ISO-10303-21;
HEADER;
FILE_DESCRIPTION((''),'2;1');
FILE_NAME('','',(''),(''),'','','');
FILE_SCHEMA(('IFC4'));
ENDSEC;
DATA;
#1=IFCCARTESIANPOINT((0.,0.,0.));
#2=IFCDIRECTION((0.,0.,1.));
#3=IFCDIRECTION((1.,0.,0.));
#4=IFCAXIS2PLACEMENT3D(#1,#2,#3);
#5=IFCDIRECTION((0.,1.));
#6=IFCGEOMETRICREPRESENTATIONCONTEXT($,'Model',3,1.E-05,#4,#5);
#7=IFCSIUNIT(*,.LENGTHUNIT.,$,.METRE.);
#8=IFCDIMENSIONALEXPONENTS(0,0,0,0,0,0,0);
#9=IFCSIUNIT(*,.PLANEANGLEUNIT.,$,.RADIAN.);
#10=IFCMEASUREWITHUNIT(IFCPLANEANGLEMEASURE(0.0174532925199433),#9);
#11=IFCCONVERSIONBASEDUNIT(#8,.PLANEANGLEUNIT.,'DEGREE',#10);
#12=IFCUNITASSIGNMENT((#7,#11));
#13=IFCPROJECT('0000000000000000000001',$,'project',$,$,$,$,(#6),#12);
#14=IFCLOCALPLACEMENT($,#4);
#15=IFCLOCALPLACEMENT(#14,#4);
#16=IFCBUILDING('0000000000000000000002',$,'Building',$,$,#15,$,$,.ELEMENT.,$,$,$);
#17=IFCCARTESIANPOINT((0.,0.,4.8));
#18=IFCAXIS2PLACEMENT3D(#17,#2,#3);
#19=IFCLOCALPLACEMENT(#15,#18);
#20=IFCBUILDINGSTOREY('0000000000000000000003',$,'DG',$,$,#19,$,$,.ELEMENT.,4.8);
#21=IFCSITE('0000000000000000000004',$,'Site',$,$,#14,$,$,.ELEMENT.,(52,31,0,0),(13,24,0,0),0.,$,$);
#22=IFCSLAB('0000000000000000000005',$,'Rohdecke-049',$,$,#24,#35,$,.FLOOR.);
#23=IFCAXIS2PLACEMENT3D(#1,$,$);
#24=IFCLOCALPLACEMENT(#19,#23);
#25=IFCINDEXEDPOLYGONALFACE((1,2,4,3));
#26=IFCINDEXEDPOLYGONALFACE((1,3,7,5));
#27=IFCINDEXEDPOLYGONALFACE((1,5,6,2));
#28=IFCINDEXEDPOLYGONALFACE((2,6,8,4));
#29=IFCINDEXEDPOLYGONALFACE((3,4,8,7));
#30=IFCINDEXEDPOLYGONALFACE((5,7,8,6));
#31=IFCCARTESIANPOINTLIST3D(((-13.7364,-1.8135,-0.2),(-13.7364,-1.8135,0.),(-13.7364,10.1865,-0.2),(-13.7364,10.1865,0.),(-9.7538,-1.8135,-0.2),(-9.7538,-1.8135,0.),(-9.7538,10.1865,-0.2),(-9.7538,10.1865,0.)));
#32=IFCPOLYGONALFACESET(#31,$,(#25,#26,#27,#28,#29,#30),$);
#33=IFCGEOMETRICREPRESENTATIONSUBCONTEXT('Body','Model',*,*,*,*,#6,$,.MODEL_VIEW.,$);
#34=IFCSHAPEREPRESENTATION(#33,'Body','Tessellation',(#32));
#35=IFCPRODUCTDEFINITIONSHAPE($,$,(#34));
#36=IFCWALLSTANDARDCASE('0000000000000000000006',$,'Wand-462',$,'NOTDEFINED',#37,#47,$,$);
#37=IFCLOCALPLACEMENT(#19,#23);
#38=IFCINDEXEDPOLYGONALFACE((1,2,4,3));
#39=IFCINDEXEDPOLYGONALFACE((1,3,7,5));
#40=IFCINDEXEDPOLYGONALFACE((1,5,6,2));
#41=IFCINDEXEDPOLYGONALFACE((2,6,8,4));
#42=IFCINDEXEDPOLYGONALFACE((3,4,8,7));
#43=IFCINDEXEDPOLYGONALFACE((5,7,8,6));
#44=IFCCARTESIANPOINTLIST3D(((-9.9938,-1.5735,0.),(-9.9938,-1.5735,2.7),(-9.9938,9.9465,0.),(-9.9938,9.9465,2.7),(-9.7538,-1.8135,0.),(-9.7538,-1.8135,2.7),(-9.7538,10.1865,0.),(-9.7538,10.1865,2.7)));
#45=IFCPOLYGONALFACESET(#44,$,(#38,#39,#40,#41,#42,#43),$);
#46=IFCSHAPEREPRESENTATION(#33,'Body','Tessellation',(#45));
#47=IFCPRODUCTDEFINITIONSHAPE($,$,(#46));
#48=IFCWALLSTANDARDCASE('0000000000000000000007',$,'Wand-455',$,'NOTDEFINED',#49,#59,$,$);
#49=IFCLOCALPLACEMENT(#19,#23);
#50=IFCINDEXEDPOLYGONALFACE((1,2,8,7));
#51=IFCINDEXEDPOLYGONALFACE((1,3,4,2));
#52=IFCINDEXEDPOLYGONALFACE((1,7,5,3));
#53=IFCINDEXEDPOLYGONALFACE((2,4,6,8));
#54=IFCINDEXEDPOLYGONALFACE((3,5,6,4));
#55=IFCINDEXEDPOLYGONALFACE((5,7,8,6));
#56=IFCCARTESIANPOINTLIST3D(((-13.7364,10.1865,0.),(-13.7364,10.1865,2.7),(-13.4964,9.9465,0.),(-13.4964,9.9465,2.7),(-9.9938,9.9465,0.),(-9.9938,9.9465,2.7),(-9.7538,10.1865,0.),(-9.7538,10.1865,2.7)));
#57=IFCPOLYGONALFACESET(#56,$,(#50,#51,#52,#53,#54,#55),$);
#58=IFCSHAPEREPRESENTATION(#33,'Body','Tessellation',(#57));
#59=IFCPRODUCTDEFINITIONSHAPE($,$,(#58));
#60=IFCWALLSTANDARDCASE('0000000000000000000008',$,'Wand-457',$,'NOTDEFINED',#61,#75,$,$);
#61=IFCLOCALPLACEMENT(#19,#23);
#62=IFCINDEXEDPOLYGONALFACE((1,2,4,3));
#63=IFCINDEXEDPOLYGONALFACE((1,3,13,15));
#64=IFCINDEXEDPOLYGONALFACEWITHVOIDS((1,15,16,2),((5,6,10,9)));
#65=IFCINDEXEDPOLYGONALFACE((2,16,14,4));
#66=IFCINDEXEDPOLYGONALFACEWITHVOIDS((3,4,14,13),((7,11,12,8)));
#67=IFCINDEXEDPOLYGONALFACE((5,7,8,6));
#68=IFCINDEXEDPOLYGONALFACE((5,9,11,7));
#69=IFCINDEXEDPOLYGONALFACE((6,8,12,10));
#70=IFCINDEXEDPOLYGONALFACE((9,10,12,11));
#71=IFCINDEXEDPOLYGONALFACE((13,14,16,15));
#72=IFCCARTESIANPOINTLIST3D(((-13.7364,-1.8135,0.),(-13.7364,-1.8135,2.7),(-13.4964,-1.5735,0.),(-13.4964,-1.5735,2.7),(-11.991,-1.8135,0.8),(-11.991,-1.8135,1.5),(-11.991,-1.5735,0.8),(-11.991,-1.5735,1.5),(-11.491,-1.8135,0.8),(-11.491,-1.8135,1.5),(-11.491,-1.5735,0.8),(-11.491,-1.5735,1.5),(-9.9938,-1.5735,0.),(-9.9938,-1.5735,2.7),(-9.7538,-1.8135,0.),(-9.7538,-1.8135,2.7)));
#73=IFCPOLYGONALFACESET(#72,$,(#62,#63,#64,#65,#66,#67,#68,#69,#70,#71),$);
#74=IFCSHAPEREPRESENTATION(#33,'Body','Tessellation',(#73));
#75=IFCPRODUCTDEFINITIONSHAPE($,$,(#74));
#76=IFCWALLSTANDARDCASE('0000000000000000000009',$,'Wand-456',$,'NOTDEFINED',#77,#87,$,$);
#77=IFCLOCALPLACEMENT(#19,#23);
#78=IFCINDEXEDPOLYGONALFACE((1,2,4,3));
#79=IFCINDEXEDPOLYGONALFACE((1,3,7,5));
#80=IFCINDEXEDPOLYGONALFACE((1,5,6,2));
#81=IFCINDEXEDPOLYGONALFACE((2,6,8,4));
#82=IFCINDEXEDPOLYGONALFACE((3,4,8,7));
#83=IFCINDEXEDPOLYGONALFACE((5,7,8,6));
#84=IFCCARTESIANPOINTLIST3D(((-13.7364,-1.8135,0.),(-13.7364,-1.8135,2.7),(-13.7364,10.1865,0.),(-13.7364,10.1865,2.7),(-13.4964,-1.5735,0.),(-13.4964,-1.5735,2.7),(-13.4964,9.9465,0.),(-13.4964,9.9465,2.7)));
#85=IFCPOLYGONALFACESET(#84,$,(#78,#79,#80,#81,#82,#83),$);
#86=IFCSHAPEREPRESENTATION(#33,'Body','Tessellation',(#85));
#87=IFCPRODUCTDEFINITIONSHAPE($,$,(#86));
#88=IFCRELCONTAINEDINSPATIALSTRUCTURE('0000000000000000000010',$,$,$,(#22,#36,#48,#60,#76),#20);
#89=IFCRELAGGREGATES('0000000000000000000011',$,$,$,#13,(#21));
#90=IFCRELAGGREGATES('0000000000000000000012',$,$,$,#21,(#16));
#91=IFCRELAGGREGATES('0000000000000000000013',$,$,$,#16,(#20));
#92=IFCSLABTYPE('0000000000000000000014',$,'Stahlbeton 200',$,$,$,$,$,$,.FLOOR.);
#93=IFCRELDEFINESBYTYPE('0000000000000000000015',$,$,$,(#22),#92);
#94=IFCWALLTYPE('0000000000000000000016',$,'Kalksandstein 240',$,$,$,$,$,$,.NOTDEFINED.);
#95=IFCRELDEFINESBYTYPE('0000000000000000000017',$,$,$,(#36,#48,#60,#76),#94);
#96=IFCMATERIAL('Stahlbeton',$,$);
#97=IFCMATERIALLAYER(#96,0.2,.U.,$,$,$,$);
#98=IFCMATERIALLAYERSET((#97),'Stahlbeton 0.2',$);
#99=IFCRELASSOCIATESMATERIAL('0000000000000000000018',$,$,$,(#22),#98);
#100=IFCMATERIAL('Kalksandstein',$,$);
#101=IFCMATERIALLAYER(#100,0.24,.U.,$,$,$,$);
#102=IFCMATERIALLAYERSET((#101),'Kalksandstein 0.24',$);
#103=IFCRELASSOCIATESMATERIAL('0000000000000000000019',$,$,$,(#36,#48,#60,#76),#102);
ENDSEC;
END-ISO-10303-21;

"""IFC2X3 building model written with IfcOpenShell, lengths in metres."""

from ifc_helpers import new_model, entity, si_unit, converted_unit, direction, frame, origin_with_axes, origin_2d_with_axis, place, context, subcontext, project, spatial, polyline, rectangle, outline, extrude, material, layer, layer_set, layer_usage, type_object, element, save


model = new_model("IFC2X3")

# Units and contexts
model_context = context("Model", 3, precision=1e-05, world=origin_with_axes(), true_north=direction((0.0, 1.0)))
body_context = subcontext(model_context, "Body", "Model", "MODEL_VIEW")
ifc_project = project(units=[si_unit("LENGTHUNIT", "METRE"), converted_unit("PLANEANGLEUNIT", "DEGREE", entity("IfcPlaneAngleMeasure", 0.0174532925199433), si_unit("PLANEANGLEUNIT", "RADIAN"), dimensions=[0, 0, 0, 0, 0, 0, 0])], contexts=[model_context])

# Site, building, storey
site_placement = place(None, origin_with_axes())
site = spatial("IfcSite", under=ifc_project, at=site_placement, Name="Site", CompositionType="ELEMENT", RefLatitude=(52, 31, 0, 0), RefLongitude=(13, 24, 0, 0), RefElevation=0.0)
building_placement = place(site_placement, origin_with_axes())
building = spatial("IfcBuilding", under=site, at=building_placement, Name="Building", CompositionType="ELEMENT")
storey_placement = place(building_placement, frame((0.0, 0.0, 4.8), z_axis=(0.0, 0.0, 1.0), x_axis=(1.0, 0.0, 0.0)))
storey = spatial("IfcBuildingStorey", under=building, at=storey_placement, Name="DG", CompositionType="ELEMENT", Elevation=4.8)

# Slab
ifc_material_1 = material(Name="Stahlbeton")
ifc_layer_1 = layer(ifc_material_1, 0.2, ventilated="UNKNOWN")
ifc_layer_set_1 = layer_set([ifc_layer_1], Name="Stahlbeton 0.2")
ifc_layer_usage_1 = layer_usage(ifc_layer_set_1, "AXIS3", "NEGATIVE", 0.2)
slab_type = type_object("IfcSlabType", Name="Stahlbeton 200", PredefinedType="FLOOR")
slab_placement = place(storey_placement, frame((-9.7538, 10.1865, 0.0), z_axis=(0.0, 0.0, 1.0), x_axis=(1.0, 0.0, 0.0)))
element("IfcSlab", 1, at=slab_placement, inside=storey, type_object=slab_type, material=ifc_layer_usage_1, Name="Rohdecke-049", PredefinedType="FLOOR", context=body_context, shape_type="SweptSolid", body=[
    extrude(outline(polyline([(0.0, 0.0), (-3.9826, 0.0), (-3.9826, -12.0), (0.0, -12.0), (0.0, 0.0)])), frame((0.0, 0.0, -0.2), z_axis=(0.0, 0.0, 1.0), x_axis=(1.0, 0.0, 0.0)), (0.0, 0.0, 1.0), 0.2),
])

# Walls
ifc_material_2 = material(Name="Kalksandstein")
ifc_layer_2 = layer(ifc_material_2, 0.24, ventilated="UNKNOWN")
ifc_layer_set_2 = layer_set([ifc_layer_2], Name="Kalksandstein 0.24")
ifc_layer_usage_2 = layer_usage(ifc_layer_set_2, "AXIS2", "POSITIVE", 0.0)
wall_type = type_object("IfcWallType", Name="Kalksandstein 240", PredefinedType="NOTDEFINED")
wall_1_placement = place(storey_placement, frame((-9.7538, -1.8135, 0.0), z_axis=(0.0, 0.0, 1.0), x_axis=(0.0, 1.0, 0.0)))
element("IfcWallStandardCase", 2, at=wall_1_placement, inside=storey, type_object=wall_type, material=ifc_layer_usage_2, Name="Wand-462", ObjectType="NOTDEFINED", context=body_context, shape_type="SweptSolid", body=[
    extrude(outline(polyline([(0.0, 0.0), (12.0, 0.0), (11.76, 0.24), (0.24, 0.24), (0.0, 0.0)])), origin_with_axes(), (0.0, 0.0, 1.0), 2.7),
])
ifc_layer_usage_3 = layer_usage(ifc_layer_set_2, "AXIS2", "POSITIVE", 0.0)
wall_2_placement = place(storey_placement, frame((-9.7538, 10.1865, 0.0), z_axis=(0.0, 0.0, 1.0), x_axis=(-1.0, 0.0, 0.0)))
element("IfcWallStandardCase", 3, at=wall_2_placement, inside=storey, type_object=wall_type, material=ifc_layer_usage_3, Name="Wand-455", ObjectType="NOTDEFINED", context=body_context, shape_type="SweptSolid", body=[
    extrude(outline(polyline([(0.0, 0.0), (3.9826, 0.0), (3.7426, 0.24), (0.24, 0.24), (0.0, 0.0)])), origin_with_axes(), (0.0, 0.0, 1.0), 2.7),
])

# Wall, opening
ifc_layer_usage_4 = layer_usage(ifc_layer_set_2, "AXIS2", "POSITIVE", 0.0)
wall_3_placement = place(storey_placement, frame((-13.7364, -1.8135, 0.0), z_axis=(0.0, 0.0, 1.0), x_axis=(1.0, 0.0, 0.0)))
wall_3 = element("IfcWallStandardCase", 4, at=wall_3_placement, inside=storey, type_object=wall_type, material=ifc_layer_usage_4, Name="Wand-457", ObjectType="NOTDEFINED", context=body_context, shape_type="SweptSolid", body=[
    extrude(outline(polyline([(0.0, 0.0), (3.9826, 0.0), (3.7426, 0.24), (0.24, 0.24), (0.0, 0.0)])), origin_with_axes(), (0.0, 0.0, 1.0), 2.7),
])
opening_placement = place(wall_3_placement, frame((1.9954, 0.0, 0.8), z_axis=(0.0, 0.0, 1.0), x_axis=(1.0, 0.0, 0.0)))
element("IfcOpeningElement", 5, at=opening_placement, cuts=wall_3, context=body_context, shape_type="SweptSolid", body=[
    extrude(rectangle(XDim=0.5, YDim=0.7, at=origin_2d_with_axis()), frame((0.0, 0.24, 0.35), z_axis=(0.0, 1.0, 0.0), x_axis=(1.0, 0.0, 0.0)), (0.0, 0.0, -1.0), 0.72),
])

# Wall
ifc_layer_usage_5 = layer_usage(ifc_layer_set_2, "AXIS2", "POSITIVE", 0.0)
wall_4_placement = place(storey_placement, frame((-13.7364, 10.1865, 0.0), z_axis=(0.0, 0.0, 1.0), x_axis=(0.0, -1.0, 0.0)))
element("IfcWallStandardCase", 6, at=wall_4_placement, inside=storey, type_object=wall_type, material=ifc_layer_usage_5, Name="Wand-456", ObjectType="NOTDEFINED", context=body_context, shape_type="SweptSolid", body=[
    extrude(outline(polyline([(0.0, 0.0), (12.0, 0.0), (11.76, 0.24), (0.24, 0.24), (0.0, 0.0)])), origin_with_axes(), (0.0, 0.0, 1.0), 2.7),
])

save(model, "model.ifc")
